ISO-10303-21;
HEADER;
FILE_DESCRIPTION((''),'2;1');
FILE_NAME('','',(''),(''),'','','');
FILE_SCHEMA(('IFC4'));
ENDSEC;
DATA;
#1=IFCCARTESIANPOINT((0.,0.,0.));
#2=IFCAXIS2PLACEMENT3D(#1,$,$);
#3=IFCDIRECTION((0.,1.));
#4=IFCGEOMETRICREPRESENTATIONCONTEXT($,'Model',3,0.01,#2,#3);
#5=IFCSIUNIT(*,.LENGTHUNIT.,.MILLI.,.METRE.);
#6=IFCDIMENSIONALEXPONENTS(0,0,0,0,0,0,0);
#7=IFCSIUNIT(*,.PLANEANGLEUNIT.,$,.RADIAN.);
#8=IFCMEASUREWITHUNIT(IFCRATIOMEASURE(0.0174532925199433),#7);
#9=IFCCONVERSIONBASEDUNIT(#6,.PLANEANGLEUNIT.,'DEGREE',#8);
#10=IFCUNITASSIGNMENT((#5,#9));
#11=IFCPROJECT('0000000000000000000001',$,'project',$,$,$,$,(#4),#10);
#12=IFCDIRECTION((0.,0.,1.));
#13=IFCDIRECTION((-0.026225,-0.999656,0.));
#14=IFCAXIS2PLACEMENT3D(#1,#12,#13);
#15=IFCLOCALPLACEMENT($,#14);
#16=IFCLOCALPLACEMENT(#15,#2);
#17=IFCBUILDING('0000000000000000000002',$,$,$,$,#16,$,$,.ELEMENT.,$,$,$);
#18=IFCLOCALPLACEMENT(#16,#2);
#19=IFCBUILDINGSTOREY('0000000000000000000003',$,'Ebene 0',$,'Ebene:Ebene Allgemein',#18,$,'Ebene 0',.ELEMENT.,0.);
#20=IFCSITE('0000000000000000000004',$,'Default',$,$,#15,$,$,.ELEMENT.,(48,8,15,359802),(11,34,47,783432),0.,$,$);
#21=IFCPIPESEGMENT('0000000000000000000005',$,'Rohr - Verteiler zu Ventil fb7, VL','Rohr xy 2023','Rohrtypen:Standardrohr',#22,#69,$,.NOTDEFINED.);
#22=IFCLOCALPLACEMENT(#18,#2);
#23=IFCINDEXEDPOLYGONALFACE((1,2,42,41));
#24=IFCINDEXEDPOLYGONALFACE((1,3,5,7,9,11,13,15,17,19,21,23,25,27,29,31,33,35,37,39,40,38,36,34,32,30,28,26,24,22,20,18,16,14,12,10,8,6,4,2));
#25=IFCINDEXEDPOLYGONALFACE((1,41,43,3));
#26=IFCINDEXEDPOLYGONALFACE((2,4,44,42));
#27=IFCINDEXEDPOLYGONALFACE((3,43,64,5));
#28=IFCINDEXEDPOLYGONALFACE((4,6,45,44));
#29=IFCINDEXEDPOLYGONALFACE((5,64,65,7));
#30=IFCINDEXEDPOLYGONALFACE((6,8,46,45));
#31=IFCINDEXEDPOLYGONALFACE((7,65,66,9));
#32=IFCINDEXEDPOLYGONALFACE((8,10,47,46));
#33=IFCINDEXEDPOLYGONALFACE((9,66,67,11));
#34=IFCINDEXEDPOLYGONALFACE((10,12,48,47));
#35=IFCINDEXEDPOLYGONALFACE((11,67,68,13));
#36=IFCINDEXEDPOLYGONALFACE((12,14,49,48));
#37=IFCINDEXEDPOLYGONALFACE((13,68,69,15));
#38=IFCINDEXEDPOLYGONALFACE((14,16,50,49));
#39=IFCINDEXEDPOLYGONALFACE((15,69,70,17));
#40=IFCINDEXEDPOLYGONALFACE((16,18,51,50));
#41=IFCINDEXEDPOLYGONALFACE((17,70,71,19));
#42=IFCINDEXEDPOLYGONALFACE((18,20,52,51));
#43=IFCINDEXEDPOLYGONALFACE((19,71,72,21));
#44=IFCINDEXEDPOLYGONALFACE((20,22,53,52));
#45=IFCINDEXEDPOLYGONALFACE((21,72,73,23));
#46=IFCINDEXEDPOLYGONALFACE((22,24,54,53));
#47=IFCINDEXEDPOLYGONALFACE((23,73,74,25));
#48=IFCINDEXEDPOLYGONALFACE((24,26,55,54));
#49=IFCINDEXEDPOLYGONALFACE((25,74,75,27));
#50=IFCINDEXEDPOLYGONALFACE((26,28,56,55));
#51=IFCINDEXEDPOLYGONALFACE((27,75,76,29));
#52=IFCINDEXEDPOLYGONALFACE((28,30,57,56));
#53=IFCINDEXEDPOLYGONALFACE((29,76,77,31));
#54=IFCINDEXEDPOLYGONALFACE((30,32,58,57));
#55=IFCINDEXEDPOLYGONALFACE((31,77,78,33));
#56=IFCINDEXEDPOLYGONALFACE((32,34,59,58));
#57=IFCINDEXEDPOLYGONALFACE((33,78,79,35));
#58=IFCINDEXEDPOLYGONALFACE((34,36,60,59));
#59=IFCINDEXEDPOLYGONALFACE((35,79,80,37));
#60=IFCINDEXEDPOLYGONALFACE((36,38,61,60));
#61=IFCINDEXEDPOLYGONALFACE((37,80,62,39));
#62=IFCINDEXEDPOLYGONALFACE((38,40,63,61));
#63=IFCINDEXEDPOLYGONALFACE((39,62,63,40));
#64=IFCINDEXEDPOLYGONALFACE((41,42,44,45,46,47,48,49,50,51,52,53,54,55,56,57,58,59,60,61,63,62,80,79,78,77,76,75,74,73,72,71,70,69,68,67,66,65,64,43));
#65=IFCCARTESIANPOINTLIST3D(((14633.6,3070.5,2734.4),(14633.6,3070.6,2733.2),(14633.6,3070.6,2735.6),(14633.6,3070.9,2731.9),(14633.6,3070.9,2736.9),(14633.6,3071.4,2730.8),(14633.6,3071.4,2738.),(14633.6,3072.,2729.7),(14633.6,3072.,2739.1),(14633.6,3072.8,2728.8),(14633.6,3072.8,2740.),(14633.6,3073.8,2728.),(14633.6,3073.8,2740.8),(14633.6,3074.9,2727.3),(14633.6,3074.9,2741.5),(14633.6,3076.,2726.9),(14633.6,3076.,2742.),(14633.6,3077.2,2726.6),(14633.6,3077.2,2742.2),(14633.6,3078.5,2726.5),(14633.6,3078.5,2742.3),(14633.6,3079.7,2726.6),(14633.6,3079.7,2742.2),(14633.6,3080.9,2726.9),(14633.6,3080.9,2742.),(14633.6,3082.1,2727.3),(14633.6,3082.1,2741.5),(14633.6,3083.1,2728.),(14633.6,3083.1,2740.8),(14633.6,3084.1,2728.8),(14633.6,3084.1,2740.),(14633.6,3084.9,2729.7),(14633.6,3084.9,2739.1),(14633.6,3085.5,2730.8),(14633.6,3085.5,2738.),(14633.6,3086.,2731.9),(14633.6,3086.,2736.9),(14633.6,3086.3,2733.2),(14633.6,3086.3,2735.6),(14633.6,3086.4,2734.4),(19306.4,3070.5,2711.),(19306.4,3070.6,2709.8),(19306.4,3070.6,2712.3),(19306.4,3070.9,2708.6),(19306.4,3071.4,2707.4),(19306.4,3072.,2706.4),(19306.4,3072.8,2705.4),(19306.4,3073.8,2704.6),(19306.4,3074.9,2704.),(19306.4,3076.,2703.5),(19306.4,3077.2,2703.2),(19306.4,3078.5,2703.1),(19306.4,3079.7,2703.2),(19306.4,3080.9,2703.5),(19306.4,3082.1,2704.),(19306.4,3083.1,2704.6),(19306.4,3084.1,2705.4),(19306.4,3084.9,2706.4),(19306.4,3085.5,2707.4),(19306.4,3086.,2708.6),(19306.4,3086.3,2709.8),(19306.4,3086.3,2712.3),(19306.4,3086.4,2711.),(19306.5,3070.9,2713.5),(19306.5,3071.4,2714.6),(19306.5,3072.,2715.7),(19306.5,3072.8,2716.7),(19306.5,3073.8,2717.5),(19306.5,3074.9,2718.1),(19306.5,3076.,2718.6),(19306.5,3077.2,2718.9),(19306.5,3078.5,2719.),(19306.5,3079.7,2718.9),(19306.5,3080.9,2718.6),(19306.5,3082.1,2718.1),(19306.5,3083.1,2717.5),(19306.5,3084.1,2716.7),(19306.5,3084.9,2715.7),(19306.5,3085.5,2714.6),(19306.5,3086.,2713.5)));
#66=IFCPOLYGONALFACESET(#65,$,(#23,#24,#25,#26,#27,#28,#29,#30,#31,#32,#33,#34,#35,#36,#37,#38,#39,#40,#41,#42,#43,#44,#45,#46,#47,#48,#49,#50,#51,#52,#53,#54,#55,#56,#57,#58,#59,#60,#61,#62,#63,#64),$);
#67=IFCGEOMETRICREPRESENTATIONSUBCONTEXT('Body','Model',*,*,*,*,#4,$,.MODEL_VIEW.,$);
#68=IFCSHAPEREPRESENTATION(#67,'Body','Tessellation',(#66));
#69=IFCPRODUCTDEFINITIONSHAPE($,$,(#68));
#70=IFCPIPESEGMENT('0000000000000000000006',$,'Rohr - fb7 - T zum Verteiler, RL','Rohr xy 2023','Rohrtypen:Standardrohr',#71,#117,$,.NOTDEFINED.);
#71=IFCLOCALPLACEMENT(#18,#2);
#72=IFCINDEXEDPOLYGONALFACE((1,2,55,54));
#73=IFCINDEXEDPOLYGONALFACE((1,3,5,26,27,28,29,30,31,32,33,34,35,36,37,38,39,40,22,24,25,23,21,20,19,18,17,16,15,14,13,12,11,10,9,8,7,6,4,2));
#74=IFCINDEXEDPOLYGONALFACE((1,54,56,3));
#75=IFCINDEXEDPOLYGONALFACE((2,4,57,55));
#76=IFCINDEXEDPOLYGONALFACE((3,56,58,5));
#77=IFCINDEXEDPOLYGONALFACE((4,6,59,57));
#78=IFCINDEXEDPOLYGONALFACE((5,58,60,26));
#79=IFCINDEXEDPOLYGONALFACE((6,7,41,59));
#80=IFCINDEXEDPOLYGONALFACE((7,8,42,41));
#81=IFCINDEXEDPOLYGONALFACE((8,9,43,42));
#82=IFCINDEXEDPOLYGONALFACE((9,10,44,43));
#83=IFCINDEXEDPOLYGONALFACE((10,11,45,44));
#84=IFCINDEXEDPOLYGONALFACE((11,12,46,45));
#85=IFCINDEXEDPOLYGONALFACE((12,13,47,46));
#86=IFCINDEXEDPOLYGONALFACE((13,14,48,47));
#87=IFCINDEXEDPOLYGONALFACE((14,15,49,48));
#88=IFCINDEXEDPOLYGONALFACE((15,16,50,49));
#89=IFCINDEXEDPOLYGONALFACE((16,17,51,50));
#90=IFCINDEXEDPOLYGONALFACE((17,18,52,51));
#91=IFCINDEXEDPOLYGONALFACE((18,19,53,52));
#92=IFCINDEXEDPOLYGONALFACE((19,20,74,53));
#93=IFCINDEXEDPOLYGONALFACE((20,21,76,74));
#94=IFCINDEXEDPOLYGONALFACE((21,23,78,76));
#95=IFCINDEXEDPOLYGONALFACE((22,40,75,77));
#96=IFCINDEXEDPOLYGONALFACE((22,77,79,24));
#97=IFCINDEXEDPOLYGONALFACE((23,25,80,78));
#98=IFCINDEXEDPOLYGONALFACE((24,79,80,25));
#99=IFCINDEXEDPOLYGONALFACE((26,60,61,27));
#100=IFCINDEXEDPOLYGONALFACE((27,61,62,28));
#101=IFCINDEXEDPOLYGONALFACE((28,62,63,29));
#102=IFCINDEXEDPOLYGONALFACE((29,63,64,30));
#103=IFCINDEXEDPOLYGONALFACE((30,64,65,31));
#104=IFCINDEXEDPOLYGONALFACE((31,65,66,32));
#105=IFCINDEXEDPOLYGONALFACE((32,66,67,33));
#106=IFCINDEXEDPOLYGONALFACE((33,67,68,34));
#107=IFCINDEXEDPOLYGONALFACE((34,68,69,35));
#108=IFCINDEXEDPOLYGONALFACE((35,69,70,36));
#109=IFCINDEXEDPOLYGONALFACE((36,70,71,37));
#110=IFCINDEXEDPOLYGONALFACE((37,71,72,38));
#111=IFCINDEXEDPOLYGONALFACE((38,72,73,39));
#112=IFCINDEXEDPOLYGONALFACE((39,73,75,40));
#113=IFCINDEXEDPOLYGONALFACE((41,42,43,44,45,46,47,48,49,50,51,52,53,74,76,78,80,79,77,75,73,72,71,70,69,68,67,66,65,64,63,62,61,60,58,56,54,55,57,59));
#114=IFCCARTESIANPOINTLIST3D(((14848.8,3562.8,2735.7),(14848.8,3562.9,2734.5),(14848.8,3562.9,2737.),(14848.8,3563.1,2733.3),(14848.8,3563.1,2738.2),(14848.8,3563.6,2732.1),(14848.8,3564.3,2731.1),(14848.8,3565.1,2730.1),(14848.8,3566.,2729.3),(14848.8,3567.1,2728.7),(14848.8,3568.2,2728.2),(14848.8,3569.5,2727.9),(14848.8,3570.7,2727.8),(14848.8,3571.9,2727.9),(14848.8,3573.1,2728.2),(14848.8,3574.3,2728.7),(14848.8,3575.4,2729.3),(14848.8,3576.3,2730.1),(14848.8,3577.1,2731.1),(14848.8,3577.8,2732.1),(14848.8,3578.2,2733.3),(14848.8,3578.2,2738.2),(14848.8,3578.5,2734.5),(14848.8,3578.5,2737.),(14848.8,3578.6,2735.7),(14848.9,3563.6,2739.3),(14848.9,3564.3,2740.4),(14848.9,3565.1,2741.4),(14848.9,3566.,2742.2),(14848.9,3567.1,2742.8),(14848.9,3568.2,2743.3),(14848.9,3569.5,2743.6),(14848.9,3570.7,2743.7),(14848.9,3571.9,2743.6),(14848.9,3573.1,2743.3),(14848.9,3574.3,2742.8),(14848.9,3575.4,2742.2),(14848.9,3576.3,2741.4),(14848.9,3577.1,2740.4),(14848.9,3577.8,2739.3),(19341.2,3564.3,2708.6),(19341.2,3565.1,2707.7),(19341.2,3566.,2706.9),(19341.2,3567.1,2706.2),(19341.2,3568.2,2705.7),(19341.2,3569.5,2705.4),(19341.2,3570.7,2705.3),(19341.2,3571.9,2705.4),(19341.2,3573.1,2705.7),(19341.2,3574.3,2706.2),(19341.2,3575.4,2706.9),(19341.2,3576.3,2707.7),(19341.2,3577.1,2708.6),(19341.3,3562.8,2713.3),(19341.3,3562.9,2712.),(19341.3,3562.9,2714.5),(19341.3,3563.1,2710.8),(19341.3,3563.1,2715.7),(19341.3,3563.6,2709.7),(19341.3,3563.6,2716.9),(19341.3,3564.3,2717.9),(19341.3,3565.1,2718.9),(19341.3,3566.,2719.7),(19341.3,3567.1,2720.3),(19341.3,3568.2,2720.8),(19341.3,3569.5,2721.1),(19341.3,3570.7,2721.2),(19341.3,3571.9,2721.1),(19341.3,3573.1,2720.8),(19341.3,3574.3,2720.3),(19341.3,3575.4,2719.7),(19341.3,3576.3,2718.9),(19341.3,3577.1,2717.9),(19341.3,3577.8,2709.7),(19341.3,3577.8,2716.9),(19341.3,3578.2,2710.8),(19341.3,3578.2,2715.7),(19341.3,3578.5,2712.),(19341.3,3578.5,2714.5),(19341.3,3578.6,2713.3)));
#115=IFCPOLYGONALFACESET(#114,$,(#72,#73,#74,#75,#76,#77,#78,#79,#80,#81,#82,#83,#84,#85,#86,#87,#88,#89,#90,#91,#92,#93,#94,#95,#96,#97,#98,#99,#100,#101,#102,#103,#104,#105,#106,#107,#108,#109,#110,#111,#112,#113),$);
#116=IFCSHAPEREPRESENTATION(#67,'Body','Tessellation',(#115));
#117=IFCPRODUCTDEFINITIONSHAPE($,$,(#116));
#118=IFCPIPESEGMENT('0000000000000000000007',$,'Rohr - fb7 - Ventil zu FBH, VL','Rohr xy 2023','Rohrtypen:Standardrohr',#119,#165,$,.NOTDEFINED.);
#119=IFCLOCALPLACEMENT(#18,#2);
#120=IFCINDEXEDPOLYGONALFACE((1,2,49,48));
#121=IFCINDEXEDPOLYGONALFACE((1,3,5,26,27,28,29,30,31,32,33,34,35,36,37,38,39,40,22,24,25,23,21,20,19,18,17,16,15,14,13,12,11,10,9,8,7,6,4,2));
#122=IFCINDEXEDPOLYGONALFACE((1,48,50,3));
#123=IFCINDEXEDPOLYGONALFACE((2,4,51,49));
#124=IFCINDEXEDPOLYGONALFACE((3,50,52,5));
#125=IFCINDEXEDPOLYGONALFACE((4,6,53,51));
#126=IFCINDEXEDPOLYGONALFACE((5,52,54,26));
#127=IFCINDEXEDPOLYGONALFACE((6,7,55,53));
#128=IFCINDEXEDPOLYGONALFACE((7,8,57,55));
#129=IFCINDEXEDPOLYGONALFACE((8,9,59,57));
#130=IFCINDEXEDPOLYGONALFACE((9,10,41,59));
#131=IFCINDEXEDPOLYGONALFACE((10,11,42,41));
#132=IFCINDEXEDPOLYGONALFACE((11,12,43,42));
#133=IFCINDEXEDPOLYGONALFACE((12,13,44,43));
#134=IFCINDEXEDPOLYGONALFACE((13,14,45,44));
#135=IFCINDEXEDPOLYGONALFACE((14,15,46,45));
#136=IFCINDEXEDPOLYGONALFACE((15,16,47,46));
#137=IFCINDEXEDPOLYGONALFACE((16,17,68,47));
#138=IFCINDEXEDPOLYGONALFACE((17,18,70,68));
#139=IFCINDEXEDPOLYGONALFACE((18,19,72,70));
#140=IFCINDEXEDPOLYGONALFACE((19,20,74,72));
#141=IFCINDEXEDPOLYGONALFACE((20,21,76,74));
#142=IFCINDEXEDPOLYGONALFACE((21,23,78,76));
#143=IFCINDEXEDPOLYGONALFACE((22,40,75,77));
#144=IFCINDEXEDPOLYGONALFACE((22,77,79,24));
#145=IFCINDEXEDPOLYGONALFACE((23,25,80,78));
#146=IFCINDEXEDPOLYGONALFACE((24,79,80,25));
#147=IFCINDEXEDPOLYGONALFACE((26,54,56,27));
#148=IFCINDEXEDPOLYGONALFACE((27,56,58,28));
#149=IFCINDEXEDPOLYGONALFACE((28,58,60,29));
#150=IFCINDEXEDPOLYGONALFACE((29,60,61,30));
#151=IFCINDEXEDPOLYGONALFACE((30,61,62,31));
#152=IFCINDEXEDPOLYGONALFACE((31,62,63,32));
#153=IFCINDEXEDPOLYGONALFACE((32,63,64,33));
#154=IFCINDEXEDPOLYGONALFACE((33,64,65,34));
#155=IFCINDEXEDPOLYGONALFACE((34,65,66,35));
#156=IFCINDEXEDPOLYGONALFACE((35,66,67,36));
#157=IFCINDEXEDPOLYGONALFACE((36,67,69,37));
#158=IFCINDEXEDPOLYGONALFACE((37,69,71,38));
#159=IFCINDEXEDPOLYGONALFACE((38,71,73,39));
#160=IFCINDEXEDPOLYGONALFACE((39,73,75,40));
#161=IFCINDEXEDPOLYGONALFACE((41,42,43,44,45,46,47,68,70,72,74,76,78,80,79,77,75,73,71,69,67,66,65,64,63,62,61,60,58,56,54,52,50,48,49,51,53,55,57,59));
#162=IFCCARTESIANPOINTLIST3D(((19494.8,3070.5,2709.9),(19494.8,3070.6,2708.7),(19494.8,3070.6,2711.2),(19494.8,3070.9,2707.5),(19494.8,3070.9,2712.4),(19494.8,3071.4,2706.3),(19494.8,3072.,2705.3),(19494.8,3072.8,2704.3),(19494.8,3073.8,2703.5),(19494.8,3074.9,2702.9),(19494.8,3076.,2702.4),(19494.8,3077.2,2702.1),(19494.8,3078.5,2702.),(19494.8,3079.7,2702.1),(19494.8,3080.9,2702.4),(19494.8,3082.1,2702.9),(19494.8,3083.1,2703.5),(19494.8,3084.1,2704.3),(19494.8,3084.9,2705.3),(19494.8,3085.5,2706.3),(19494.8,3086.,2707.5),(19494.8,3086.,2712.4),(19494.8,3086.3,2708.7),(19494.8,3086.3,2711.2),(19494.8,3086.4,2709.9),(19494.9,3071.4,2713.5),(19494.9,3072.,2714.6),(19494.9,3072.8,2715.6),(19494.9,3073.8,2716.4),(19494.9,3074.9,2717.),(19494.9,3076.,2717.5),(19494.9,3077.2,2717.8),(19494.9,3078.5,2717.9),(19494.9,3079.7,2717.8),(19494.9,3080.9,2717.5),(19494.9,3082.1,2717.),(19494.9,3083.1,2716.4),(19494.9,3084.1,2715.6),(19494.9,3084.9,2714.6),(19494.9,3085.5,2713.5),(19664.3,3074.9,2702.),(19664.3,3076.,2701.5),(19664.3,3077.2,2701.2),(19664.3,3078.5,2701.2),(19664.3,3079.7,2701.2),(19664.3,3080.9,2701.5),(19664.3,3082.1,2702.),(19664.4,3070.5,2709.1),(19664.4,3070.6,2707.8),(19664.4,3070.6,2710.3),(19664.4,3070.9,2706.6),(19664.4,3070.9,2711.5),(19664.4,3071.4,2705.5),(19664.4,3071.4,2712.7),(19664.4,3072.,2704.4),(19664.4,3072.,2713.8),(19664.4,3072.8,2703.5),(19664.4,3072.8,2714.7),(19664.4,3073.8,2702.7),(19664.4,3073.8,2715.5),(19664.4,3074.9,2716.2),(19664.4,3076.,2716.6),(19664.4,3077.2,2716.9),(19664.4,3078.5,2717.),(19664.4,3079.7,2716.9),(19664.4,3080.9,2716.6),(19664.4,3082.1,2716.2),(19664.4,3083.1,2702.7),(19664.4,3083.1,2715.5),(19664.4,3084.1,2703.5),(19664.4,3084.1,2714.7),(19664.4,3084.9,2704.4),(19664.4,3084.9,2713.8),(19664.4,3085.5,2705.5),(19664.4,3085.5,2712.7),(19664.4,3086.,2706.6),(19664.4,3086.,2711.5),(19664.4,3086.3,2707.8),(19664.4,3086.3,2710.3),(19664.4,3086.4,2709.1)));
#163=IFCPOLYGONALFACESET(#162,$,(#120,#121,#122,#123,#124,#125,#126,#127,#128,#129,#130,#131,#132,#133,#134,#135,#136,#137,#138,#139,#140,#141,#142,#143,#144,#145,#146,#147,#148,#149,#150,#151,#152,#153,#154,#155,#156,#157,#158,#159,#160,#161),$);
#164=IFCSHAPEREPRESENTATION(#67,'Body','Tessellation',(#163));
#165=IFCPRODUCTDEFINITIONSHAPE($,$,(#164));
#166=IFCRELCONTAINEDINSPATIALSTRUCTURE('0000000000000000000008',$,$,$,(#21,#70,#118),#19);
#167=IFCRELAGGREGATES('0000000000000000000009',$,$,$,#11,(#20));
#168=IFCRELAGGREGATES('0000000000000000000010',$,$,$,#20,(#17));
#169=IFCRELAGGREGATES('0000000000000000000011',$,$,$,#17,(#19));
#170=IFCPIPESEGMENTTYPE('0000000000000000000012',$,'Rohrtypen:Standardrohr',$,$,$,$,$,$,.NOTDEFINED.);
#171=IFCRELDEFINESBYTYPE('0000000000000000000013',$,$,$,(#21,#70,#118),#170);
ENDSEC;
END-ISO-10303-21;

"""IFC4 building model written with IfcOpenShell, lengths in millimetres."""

from ifc_helpers import new_model, entity, si_unit, converted_unit, direction, frame, origin, place, context, subcontext, project, spatial, indexed_curve, outline, extrude, type_object, element, save


model = new_model("IFC4")

# Units and contexts
model_context = context("Model", 3, precision=0.01, world=origin(), true_north=direction((0.0, 1.0)))
body_context = subcontext(model_context, "Body", "Model", "MODEL_VIEW")
ifc_project = project(units=[si_unit("LENGTHUNIT", "METRE", prefix="MILLI"), converted_unit("PLANEANGLEUNIT", "DEGREE", entity("IfcRatioMeasure", 0.0174532925199433), si_unit("PLANEANGLEUNIT", "RADIAN"), dimensions=[0, 0, 0, 0, 0, 0, 0])], contexts=[model_context])

# Site, building, storey
site_placement = place(None, frame((0.0, 0.0, 0.0), z_axis=(0.0, 0.0, 1.0), x_axis=(-0.026225, -0.999656, 0.0)))
site = spatial("IfcSite", under=ifc_project, at=site_placement, Name="Default", CompositionType="ELEMENT", RefLatitude=(48, 8, 15, 359802), RefLongitude=(11, 34, 47, 783432), RefElevation=0.0)
building_placement = place(site_placement, origin())
building = spatial("IfcBuilding", under=site, at=building_placement, CompositionType="ELEMENT")
storey_placement = place(building_placement, origin())
storey = spatial("IfcBuildingStorey", under=building, at=storey_placement, Name="Ebene 0", ObjectType="Ebene:Ebene Allgemein", LongName="Ebene 0", CompositionType="ELEMENT", Elevation=0.0)

# Pipe segments
pipe_segment_type = type_object("IfcPipeSegmentType", Name="Rohrtypen:Standardrohr", PredefinedType="NOTDEFINED")
pipe_segment_1_placement = place(storey_placement, origin())
element("IfcPipeSegment", 1, at=pipe_segment_1_placement, inside=storey, type_object=pipe_segment_type, Name="Rohr - Verteiler zu Ventil fb7, VL", Description="Rohr xy 2023", ObjectType="Rohrtypen:Standardrohr", PredefinedType="NOTDEFINED", context=body_context, shape_type="SweptSolid", body=[
    extrude(outline(indexed_curve([(7.9, 0.0), (7.8, 1.2), (7.6, 2.5), (7.1, 3.6), (6.4, 4.7), (5.6, 5.6), (4.7, 6.4), (3.6, 7.1), (2.5, 7.6), (1.2, 7.8), (0.0, 7.9), (-1.2, 7.8), (-2.5, 7.6), (-3.6, 7.1), (-4.7, 6.4), (-5.6, 5.6), (-6.4, 4.7), (-7.1, 3.6), (-7.6, 2.5), (-7.8, 1.2), (-7.9, 0.0), (-7.8, -1.2), (-7.6, -2.5), (-7.1, -3.6), (-6.4, -4.7), (-5.6, -5.6), (-4.7, -6.4), (-3.6, -7.1), (-2.5, -7.6), (-1.2, -7.8), (0.0, -7.9), (1.2, -7.8), (2.5, -7.6), (3.6, -7.1), (4.7, -6.4), (5.6, -5.6), (6.4, -4.7), (7.1, -3.6), (7.6, -2.5), (7.8, -1.2), (7.9, 0.0)], self_intersect=False)), frame((19306.4, 3078.5, 2711.0), z_axis=(-0.999988, 0.0, 0.005), x_axis=(0.0, 1.0, 0.0)), (0.0, 0.0, 1.0), 4672.9),
])
pipe_segment_2_placement = place(storey_placement, origin())
element("IfcPipeSegment", 2, at=pipe_segment_2_placement, inside=storey, type_object=pipe_segment_type, Name="Rohr - fb7 - T zum Verteiler, RL", Description="Rohr xy 2023", ObjectType="Rohrtypen:Standardrohr", PredefinedType="NOTDEFINED", context=body_context, shape_type="SweptSolid", body=[
    extrude(outline(indexed_curve([(7.9, 0.0), (7.8, 1.2), (7.6, 2.5), (7.1, 3.6), (6.4, 4.7), (5.6, 5.6), (4.7, 6.4), (3.6, 7.1), (2.5, 7.6), (1.2, 7.8), (0.0, 7.9), (-1.2, 7.8), (-2.5, 7.6), (-3.6, 7.1), (-4.7, 6.4), (-5.6, 5.6), (-6.4, 4.7), (-7.1, 3.6), (-7.6, 2.5), (-7.8, 1.2), (-7.9, 0.0), (-7.8, -1.2), (-7.6, -2.5), (-7.1, -3.6), (-6.4, -4.7), (-5.6, -5.6), (-4.7, -6.4), (-3.6, -7.1), (-2.5, -7.6), (-1.2, -7.8), (0.0, -7.9), (1.2, -7.8), (2.5, -7.6), (3.6, -7.1), (4.7, -6.4), (5.6, -5.6), (6.4, -4.7), (7.1, -3.6), (7.6, -2.5), (7.8, -1.2), (7.9, 0.0)], self_intersect=False)), frame((14848.8, 3570.7, 2735.7), z_axis=(0.999988, 0.0, -0.005), x_axis=(0.0, 1.0, 0.0)), (0.0, 0.0, 1.0), 4492.5),
])
pipe_segment_3_placement = place(storey_placement, origin())
element("IfcPipeSegment", 3, at=pipe_segment_3_placement, inside=storey, type_object=pipe_segment_type, Name="Rohr - fb7 - Ventil zu FBH, VL", Description="Rohr xy 2023", ObjectType="Rohrtypen:Standardrohr", PredefinedType="NOTDEFINED", context=body_context, shape_type="SweptSolid", body=[
    extrude(outline(indexed_curve([(7.9, 0.0), (7.8, 1.2), (7.6, 2.5), (7.1, 3.6), (6.4, 4.7), (5.6, 5.6), (4.7, 6.4), (3.6, 7.1), (2.5, 7.6), (1.2, 7.8), (0.0, 7.9), (-1.2, 7.8), (-2.5, 7.6), (-3.6, 7.1), (-4.7, 6.4), (-5.6, 5.6), (-6.4, 4.7), (-7.1, 3.6), (-7.6, 2.5), (-7.8, 1.2), (-7.9, 0.0), (-7.8, -1.2), (-7.6, -2.5), (-7.1, -3.6), (-6.4, -4.7), (-5.6, -5.6), (-4.7, -6.4), (-3.6, -7.1), (-2.5, -7.6), (-1.2, -7.8), (0.0, -7.9), (1.2, -7.8), (2.5, -7.6), (3.6, -7.1), (4.7, -6.4), (5.6, -5.6), (6.4, -4.7), (7.1, -3.6), (7.6, -2.5), (7.8, -1.2), (7.9, 0.0)], self_intersect=False)), frame((19494.8, 3078.5, 2709.9), z_axis=(0.999988, 0.0, -0.005), x_axis=(0.0, 1.0, 0.0)), (0.0, 0.0, 1.0), 169.5),
])

save(model, "model.ifc")
